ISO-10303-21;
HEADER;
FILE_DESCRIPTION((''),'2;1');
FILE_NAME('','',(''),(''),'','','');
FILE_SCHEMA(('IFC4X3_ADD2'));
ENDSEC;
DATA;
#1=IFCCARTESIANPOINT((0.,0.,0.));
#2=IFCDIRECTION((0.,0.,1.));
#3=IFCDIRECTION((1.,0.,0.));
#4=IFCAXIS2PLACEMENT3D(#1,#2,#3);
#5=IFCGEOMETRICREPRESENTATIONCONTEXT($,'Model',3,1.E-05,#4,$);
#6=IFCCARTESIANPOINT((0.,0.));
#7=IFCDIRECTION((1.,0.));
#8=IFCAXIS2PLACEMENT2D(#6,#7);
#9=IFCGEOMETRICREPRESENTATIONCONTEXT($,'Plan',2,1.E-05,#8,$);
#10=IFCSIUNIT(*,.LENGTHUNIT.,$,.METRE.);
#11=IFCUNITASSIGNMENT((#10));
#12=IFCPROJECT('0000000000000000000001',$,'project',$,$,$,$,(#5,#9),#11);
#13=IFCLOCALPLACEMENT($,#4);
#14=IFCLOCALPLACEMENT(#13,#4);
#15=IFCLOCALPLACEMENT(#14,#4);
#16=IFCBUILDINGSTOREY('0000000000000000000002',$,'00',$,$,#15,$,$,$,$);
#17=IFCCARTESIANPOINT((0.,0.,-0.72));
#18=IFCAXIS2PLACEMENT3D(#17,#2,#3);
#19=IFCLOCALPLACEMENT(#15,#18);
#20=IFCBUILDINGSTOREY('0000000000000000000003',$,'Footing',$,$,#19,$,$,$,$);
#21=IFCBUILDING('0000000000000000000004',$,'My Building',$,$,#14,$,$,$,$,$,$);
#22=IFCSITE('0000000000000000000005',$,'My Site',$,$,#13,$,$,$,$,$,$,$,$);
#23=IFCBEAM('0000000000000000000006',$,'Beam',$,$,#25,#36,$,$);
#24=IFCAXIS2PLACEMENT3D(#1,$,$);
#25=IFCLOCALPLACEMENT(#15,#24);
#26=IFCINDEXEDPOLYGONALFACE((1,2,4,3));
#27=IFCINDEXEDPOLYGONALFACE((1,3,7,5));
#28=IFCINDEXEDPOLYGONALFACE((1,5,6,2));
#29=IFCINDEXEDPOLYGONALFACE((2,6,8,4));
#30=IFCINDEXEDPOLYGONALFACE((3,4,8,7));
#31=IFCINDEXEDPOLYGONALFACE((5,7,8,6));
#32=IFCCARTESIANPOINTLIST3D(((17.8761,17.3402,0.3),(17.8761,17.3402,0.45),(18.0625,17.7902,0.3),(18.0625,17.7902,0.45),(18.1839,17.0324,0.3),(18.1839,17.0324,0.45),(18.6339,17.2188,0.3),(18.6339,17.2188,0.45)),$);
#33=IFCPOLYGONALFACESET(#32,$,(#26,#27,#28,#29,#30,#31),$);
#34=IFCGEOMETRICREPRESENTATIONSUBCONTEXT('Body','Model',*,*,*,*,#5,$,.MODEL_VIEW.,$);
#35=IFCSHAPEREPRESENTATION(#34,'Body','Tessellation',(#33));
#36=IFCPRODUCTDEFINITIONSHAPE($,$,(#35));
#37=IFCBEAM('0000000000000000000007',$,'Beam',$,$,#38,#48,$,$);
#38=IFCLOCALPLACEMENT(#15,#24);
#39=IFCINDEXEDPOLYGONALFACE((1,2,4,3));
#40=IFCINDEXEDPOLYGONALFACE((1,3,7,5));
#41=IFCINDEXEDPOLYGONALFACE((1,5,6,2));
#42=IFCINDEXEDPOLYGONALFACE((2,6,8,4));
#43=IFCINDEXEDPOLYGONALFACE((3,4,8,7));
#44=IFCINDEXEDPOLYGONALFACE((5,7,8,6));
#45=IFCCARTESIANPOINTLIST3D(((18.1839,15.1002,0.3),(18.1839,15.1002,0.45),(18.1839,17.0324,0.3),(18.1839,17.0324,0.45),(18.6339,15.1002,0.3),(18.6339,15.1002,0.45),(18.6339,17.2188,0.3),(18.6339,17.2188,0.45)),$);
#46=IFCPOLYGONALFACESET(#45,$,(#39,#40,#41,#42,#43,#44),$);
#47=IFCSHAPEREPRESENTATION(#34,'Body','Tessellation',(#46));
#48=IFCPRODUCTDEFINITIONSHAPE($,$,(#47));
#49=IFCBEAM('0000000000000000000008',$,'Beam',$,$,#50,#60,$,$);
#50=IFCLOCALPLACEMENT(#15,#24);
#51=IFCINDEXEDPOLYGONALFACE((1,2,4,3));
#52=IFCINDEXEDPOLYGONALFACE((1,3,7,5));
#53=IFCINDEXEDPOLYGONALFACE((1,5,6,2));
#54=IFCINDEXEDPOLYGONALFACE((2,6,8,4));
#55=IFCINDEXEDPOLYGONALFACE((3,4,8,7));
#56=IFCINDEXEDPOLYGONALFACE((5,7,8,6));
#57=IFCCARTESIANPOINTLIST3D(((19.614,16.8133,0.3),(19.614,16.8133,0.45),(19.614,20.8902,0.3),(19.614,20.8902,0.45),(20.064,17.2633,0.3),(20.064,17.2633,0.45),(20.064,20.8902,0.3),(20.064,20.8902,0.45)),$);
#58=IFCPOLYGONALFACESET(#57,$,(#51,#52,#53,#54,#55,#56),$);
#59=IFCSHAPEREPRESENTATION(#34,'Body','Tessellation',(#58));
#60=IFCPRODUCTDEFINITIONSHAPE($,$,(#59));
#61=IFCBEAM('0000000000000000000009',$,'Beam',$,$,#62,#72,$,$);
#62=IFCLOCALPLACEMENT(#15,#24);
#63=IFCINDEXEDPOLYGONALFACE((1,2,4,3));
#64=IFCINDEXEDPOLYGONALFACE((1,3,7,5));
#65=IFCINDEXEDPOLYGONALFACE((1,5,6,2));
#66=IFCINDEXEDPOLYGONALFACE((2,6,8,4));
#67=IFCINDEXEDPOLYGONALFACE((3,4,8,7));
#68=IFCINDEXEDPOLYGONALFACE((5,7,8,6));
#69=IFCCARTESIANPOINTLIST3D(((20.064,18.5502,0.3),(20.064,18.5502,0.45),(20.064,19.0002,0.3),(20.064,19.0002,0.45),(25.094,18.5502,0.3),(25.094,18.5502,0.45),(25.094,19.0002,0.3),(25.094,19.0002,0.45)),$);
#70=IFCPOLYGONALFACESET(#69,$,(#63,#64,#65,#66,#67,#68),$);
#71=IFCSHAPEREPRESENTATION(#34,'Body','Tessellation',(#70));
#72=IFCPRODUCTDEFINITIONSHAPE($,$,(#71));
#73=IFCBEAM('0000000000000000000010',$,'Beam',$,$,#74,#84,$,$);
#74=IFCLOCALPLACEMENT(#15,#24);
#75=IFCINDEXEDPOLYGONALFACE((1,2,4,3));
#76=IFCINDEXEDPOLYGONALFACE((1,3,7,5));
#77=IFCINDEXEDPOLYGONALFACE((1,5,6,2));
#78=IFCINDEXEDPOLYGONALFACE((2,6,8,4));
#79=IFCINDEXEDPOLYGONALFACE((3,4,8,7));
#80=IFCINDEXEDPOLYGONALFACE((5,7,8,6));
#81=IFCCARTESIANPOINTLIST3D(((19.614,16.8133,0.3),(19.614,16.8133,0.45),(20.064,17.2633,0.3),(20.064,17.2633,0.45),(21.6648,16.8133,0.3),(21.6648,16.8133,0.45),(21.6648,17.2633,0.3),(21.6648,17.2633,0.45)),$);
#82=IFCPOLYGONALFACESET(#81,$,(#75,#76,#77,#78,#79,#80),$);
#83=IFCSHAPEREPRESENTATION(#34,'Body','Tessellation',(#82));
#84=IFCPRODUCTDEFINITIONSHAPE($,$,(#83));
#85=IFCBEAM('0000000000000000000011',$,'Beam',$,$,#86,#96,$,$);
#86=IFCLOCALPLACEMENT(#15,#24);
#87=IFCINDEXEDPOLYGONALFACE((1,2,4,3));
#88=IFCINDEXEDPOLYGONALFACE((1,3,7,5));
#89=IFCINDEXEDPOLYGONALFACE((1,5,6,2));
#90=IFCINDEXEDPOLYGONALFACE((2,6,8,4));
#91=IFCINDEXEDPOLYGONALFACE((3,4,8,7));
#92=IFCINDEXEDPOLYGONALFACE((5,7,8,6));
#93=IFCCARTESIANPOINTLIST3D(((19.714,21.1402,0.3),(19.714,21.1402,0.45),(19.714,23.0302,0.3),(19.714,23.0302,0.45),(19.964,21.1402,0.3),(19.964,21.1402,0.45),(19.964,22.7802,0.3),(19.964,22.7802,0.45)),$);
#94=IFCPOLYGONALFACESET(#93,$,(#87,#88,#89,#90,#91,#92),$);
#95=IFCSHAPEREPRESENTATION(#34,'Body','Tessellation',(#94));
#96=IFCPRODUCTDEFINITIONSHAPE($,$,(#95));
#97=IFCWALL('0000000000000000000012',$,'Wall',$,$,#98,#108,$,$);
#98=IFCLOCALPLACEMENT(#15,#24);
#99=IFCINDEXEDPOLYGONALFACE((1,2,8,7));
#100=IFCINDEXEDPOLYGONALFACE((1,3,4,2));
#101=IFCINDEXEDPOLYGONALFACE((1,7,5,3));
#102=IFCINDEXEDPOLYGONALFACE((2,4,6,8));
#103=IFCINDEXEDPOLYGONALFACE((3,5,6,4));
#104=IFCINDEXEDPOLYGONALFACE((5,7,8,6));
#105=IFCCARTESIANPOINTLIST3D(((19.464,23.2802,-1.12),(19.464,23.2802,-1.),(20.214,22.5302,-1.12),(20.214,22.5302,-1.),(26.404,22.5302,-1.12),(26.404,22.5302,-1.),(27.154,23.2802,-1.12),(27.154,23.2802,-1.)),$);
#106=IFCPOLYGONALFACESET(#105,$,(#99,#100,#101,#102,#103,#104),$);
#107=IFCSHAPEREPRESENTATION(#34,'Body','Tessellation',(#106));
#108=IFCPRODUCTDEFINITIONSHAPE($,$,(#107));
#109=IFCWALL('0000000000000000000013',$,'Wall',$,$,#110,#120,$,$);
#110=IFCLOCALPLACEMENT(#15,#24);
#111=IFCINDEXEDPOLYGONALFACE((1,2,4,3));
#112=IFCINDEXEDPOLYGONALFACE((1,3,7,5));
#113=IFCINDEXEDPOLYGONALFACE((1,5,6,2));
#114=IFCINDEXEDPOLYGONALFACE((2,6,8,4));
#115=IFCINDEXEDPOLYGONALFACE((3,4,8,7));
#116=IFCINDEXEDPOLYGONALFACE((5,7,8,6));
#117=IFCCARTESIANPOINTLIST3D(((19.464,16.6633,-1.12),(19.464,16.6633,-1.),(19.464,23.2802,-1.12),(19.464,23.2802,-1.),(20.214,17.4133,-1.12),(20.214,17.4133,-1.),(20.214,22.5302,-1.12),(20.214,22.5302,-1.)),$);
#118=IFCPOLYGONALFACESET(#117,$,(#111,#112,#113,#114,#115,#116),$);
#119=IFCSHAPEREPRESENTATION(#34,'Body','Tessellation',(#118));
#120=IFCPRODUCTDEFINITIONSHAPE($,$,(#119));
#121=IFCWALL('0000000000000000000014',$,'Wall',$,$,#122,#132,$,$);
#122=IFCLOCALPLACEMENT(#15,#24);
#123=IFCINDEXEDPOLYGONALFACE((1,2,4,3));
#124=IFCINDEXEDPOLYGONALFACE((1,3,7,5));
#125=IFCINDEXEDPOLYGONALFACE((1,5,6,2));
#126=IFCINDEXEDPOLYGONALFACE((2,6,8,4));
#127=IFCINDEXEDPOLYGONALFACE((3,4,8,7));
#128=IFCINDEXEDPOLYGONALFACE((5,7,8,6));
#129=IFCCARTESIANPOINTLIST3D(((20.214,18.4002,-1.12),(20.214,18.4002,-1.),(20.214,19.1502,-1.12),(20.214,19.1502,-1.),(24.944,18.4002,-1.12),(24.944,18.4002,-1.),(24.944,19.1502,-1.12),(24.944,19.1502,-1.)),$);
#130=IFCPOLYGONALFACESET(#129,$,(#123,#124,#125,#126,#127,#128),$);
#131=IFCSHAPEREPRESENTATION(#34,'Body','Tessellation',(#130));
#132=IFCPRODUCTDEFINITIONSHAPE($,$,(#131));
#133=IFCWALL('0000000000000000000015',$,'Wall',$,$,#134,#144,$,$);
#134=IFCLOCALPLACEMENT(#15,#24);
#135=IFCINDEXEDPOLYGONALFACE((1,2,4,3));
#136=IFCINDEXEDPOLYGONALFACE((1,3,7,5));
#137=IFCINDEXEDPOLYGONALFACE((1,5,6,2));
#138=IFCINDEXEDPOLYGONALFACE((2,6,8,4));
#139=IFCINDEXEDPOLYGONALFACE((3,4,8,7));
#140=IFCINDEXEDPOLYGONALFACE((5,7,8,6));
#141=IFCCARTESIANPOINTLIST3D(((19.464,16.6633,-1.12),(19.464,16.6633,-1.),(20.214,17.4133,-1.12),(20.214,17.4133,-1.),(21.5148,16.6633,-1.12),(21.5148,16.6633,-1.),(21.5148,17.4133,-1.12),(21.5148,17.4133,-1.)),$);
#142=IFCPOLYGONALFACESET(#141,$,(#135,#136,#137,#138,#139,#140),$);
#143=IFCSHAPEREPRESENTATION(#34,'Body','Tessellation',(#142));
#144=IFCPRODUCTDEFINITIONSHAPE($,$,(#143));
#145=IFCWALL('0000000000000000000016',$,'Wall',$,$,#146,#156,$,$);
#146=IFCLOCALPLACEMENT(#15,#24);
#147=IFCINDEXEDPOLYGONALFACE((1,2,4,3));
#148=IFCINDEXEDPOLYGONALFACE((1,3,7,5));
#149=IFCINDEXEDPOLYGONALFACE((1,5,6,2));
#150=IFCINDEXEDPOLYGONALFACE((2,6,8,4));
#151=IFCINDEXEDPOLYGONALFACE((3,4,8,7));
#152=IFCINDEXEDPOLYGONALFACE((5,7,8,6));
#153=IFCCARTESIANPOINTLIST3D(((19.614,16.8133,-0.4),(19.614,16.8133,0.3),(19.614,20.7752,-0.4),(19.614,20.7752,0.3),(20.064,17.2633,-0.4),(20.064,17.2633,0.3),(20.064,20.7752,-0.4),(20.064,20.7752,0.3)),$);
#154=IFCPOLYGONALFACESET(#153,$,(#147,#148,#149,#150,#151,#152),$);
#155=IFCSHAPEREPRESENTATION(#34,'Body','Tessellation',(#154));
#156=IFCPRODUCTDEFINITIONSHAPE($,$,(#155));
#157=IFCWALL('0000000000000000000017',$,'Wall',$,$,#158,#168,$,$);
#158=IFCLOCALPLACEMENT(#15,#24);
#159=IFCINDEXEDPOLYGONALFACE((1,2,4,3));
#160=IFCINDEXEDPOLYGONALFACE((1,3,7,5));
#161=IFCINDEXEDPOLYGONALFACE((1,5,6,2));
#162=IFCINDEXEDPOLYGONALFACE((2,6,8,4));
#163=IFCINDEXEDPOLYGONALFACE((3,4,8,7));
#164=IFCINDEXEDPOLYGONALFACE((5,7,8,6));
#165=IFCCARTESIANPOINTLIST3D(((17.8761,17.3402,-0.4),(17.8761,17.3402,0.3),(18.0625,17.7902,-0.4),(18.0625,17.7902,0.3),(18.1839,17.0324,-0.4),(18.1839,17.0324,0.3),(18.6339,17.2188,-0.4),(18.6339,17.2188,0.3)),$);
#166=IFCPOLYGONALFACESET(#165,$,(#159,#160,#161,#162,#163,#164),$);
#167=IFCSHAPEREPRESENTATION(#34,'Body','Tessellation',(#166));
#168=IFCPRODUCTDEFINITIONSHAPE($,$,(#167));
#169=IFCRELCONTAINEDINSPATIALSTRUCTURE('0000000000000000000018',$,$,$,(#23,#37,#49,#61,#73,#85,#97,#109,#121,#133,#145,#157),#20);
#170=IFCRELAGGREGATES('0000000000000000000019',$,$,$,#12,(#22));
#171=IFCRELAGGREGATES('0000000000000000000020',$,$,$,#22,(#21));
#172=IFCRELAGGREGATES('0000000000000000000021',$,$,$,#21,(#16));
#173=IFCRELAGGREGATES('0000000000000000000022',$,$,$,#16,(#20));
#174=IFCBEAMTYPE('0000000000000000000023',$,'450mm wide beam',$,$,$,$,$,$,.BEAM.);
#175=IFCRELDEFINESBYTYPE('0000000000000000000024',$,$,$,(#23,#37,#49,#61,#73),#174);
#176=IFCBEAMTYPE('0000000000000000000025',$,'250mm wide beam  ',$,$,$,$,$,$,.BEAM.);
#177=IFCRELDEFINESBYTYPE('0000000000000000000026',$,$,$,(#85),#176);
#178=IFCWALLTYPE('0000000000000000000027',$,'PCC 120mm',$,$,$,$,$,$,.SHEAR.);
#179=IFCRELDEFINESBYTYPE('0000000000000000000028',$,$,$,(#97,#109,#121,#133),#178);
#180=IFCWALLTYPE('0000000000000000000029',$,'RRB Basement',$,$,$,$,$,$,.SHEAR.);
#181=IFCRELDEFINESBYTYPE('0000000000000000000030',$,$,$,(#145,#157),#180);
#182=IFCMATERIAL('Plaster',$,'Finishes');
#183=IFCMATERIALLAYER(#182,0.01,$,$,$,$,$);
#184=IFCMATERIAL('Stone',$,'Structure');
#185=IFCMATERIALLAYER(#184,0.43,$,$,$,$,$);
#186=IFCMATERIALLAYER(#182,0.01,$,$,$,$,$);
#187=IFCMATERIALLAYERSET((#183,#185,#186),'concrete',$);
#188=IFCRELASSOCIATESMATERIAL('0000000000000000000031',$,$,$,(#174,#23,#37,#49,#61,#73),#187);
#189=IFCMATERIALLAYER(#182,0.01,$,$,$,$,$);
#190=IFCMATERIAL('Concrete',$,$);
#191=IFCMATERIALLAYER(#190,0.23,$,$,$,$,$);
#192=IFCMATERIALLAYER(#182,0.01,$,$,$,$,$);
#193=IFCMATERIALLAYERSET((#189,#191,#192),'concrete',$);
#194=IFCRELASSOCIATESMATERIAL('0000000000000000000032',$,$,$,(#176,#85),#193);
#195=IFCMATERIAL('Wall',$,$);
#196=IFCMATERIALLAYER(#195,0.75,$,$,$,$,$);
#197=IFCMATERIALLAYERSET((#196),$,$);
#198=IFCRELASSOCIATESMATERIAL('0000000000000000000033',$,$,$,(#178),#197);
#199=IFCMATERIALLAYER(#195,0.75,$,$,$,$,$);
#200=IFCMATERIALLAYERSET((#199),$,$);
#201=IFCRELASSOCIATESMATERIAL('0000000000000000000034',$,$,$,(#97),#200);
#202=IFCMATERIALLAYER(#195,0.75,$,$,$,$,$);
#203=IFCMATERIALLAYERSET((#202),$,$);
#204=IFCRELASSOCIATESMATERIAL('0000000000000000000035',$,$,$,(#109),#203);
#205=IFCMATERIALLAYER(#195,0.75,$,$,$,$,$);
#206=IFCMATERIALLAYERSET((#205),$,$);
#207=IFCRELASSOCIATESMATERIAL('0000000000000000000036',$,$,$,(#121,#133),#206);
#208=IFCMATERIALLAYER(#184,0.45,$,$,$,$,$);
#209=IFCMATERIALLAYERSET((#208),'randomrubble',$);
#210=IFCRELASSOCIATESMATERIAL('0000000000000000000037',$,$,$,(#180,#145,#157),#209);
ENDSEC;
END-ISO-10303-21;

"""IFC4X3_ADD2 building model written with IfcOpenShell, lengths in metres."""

from ifc_helpers import new_model, si_unit, frame, origin_with_axes, origin_2d_with_axis, place, context, subcontext, project, spatial, line, indexed_curve, outline, extrude, material, layer, layer_set, layer_usage, type_object, element, save


model = new_model("IFC4X3_ADD2")

# Units and contexts
model_context = context("Model", 3, precision=1e-05, world=origin_with_axes())
plan_context = context("Plan", 2, precision=1e-05, world=origin_2d_with_axis())
body_context = subcontext(model_context, "Body", "Model", "MODEL_VIEW")
ifc_project = project(units=[si_unit("LENGTHUNIT", "METRE")], contexts=[model_context, plan_context])

# Site, building, storeys
site_placement = place(None, origin_with_axes())
site = spatial("IfcSite", under=ifc_project, at=site_placement, Name="My Site")
building_placement = place(site_placement, origin_with_axes())
building = spatial("IfcBuilding", under=site, at=building_placement, Name="My Building")
storey_1_placement = place(building_placement, origin_with_axes())
storey_1 = spatial("IfcBuildingStorey", under=building, at=storey_1_placement, Name="00")
storey_2_placement = place(storey_1_placement, frame((0.0, 0.0, -0.72), z_axis=(0.0, 0.0, 1.0), x_axis=(1.0, 0.0, 0.0)))
storey_2 = spatial("IfcBuildingStorey", under=storey_1, at=storey_2_placement, Name="Footing")

# Beams
ifc_material_1 = material(Name="Plaster", Category="Finishes")
ifc_layer_1 = layer(ifc_material_1, 0.01)
ifc_material_2 = material(Name="Stone", Category="Structure")
ifc_layer_2 = layer(ifc_material_2, 0.43)
ifc_layer_3 = layer(ifc_material_1, 0.01)
ifc_layer_set_1 = layer_set([ifc_layer_1, ifc_layer_2, ifc_layer_3], Name="concrete")
ifc_layer_usage_1 = layer_usage(ifc_layer_set_1, "AXIS2", "NEGATIVE", 0.0)
beam_type_1 = type_object("IfcBeamType", Name="450mm wide beam", PredefinedType="BEAM", material=ifc_layer_set_1)
beam_1_placement = place(storey_2_placement, frame((18.1839, 17.0324, 1.02), z_axis=(0.0, 0.0, 1.0), x_axis=(-0.707107, 0.707107, 0.0)))
element("IfcBeam", 1, at=beam_1_placement, inside=storey_2, type_object=beam_type_1, material=ifc_layer_usage_1, Name="Beam", context=body_context, shape_type="SweptSolid", body=[
    extrude(outline(indexed_curve([(-0.1864, -0.45), (0.0, 0.0), (0.4353, 0.0), (0.6217, -0.45)], segments=[line(1, 2, 3, 4, 1)])), origin_with_axes(), (0.0, 0.0, 1.0), 0.15),
])
ifc_layer_usage_2 = layer_usage(ifc_layer_set_1, "AXIS2", "POSITIVE", 0.0)
beam_2_placement = place(storey_2_placement, frame((18.1839, 17.0324, 1.02), z_axis=(0.0, 0.0, 1.0), x_axis=(0.0, -1.0, 0.0)))
element("IfcBeam", 2, at=beam_2_placement, inside=storey_2, type_object=beam_type_1, material=ifc_layer_usage_2, Name="Beam", context=body_context, shape_type="SweptSolid", body=[
    extrude(outline(indexed_curve([(0.0, 0.0), (-0.1864, 0.45), (1.9322, 0.45), (1.9322, 0.0)], segments=[line(1, 2, 3, 4, 1)])), origin_with_axes(), (0.0, 0.0, 1.0), 0.15),
])
ifc_layer_usage_3 = layer_usage(ifc_layer_set_1, "AXIS2", "NEGATIVE", 0.0)
beam_3_placement = place(storey_2_placement, frame((20.064, 20.8902, 1.02), z_axis=(0.0, 0.0, 1.0), x_axis=(0.0, -1.0, 0.0)))
element("IfcBeam", 3, at=beam_3_placement, inside=storey_2, type_object=beam_type_1, material=ifc_layer_usage_3, Name="Beam", context=body_context, shape_type="SweptSolid", body=[
    extrude(outline(indexed_curve([(0.0, -0.45), (0.0, 0.0), (3.6269, 0.0), (4.0769, -0.45)], segments=[line(1, 2, 3, 4, 1)])), origin_with_axes(), (0.0, 0.0, 1.0), 0.15),
])
ifc_layer_usage_4 = layer_usage(ifc_layer_set_1, "AXIS2", "NEGATIVE", 0.0)
beam_4_placement = place(storey_2_placement, frame((20.064, 19.0002, 1.02), z_axis=(0.0, 0.0, 1.0), x_axis=(1.0, 0.0, 0.0)))
element("IfcBeam", 4, at=beam_4_placement, inside=storey_2, type_object=beam_type_1, material=ifc_layer_usage_4, Name="Beam", context=body_context, shape_type="SweptSolid", body=[
    extrude(outline(indexed_curve([(0.0, -0.45), (0.0, 0.0), (5.03, 0.0), (5.03, -0.45)], segments=[line(1, 2, 3, 4, 1)])), origin_with_axes(), (0.0, 0.0, 1.0), 0.15),
])
ifc_layer_usage_5 = layer_usage(ifc_layer_set_1, "AXIS2", "NEGATIVE", 0.0)
beam_5_placement = place(storey_2_placement, frame((20.064, 17.2633, 1.02), z_axis=(0.0, 0.0, 1.0), x_axis=(1.0, 0.0, 0.0)))
element("IfcBeam", 5, at=beam_5_placement, inside=storey_2, type_object=beam_type_1, material=ifc_layer_usage_5, Name="Beam", context=body_context, shape_type="SweptSolid", body=[
    extrude(outline(indexed_curve([(-0.45, -0.45), (0.0, 0.0), (1.6008, 0.0), (1.6008, -0.45)], segments=[line(1, 2, 3, 4, 1)])), origin_with_axes(), (0.0, 0.0, 1.0), 0.15),
])
ifc_layer_4 = layer(ifc_material_1, 0.01)
ifc_material_3 = material(Name="Concrete")
ifc_layer_5 = layer(ifc_material_3, 0.23)
ifc_layer_6 = layer(ifc_material_1, 0.01)
ifc_layer_set_2 = layer_set([ifc_layer_4, ifc_layer_5, ifc_layer_6], Name="concrete")
ifc_layer_usage_6 = layer_usage(ifc_layer_set_2, "AXIS2", "POSITIVE", 0.0)
beam_type_2 = type_object("IfcBeamType", Name="250mm wide beam  ", PredefinedType="BEAM", material=ifc_layer_set_2)
beam_6_placement = place(storey_2_placement, frame((19.714, 22.7802, 1.02), z_axis=(0.0, 0.0, 1.0), x_axis=(0.0, -1.0, 0.0)))
element("IfcBeam", 6, at=beam_6_placement, inside=storey_2, type_object=beam_type_2, material=ifc_layer_usage_6, Name="Beam", context=body_context, shape_type="SweptSolid", body=[
    extrude(outline(indexed_curve([(-0.25, 0.0), (0.0, 0.25), (1.64, 0.25), (1.64, 0.0)], segments=[line(1, 2, 3, 4, 1)])), origin_with_axes(), (0.0, 0.0, 1.0), 0.15),
])

# Walls
ifc_material_4 = material(Name="Wall")
ifc_layer_7 = layer(ifc_material_4, 0.75)
ifc_layer_set_3 = layer_set([ifc_layer_7])
ifc_layer_usage_7 = layer_usage(ifc_layer_set_3, "AXIS2", "POSITIVE", 0.0)
ifc_layer_8 = layer(ifc_material_4, 0.75)
ifc_layer_set_4 = layer_set([ifc_layer_8])
wall_type_1 = type_object("IfcWallType", Name="PCC 120mm", PredefinedType="SHEAR", material=ifc_layer_set_4)
wall_1_placement = place(storey_2_placement, frame((20.214, 22.5302, -0.4), z_axis=(0.0, 0.0, 1.0), x_axis=(1.0, 0.0, 0.0)))
element("IfcWall", 7, at=wall_1_placement, inside=storey_2, type_object=wall_type_1, material=ifc_layer_usage_7, Name="Wall", context=body_context, shape_type="SweptSolid", body=[
    extrude(outline(indexed_curve([(0.0, 0.0), (-0.75, 0.75), (6.94, 0.75), (6.19, 0.0)], segments=[line(1, 2, 3, 4, 1)])), origin_with_axes(), (0.0, 0.0, 1.0), 0.12),
])
ifc_layer_9 = layer(ifc_material_4, 0.75)
ifc_layer_set_5 = layer_set([ifc_layer_9])
ifc_layer_usage_8 = layer_usage(ifc_layer_set_5, "AXIS2", "POSITIVE", 0.0)
wall_2_placement = place(storey_2_placement, frame((20.214, 16.6633, -0.4), z_axis=(0.0, 0.0, 1.0), x_axis=(0.0, 1.0, 0.0)))
element("IfcWall", 8, at=wall_2_placement, inside=storey_2, type_object=wall_type_1, material=ifc_layer_usage_8, Name="Wall", context=body_context, shape_type="SweptSolid", body=[
    extrude(outline(indexed_curve([(0.75, 0.0), (0.0, 0.75), (6.6169, 0.75), (5.8669, 0.0)], segments=[line(1, 2, 3, 4, 1)])), origin_with_axes(), (0.0, 0.0, 1.0), 0.12),
])
ifc_layer_10 = layer(ifc_material_4, 0.75)
ifc_layer_set_6 = layer_set([ifc_layer_10])
ifc_layer_usage_9 = layer_usage(ifc_layer_set_6, "AXIS2", "POSITIVE", 0.0)
wall_3_placement = place(storey_2_placement, frame((20.214, 18.4002, -0.4), z_axis=(0.0, 0.0, 1.0), x_axis=(1.0, 0.0, 0.0)))
element("IfcWall", 9, at=wall_3_placement, inside=storey_2, type_object=wall_type_1, material=ifc_layer_usage_9, Name="Wall", context=body_context, shape_type="SweptSolid", body=[
    extrude(outline(indexed_curve([(0.0, 0.0), (0.0, 0.75), (4.73, 0.75), (4.73, 0.0)], segments=[line(1, 2, 3, 4, 1)])), origin_with_axes(), (0.0, 0.0, 1.0), 0.12),
])
ifc_layer_usage_10 = layer_usage(ifc_layer_set_6, "AXIS2", "POSITIVE", 0.0)
wall_4_placement = place(storey_2_placement, frame((20.214, 16.6633, -0.4), z_axis=(0.0, 0.0, 1.0), x_axis=(1.0, 0.0, 0.0)))
element("IfcWall", 10, at=wall_4_placement, inside=storey_2, type_object=wall_type_1, material=ifc_layer_usage_10, Name="Wall", context=body_context, shape_type="SweptSolid", body=[
    extrude(outline(indexed_curve([(-0.75, 0.0), (0.0, 0.75), (1.3008, 0.75), (1.3008, 0.0)], segments=[line(1, 2, 3, 4, 1)])), origin_with_axes(), (0.0, 0.0, 1.0), 0.12),
])
ifc_layer_11 = layer(ifc_material_2, 0.45)
ifc_layer_set_7 = layer_set([ifc_layer_11], Name="randomrubble")
ifc_layer_usage_11 = layer_usage(ifc_layer_set_7, "AXIS2", "NEGATIVE", 0.0)
wall_type_2 = type_object("IfcWallType", Name="RRB Basement", PredefinedType="SHEAR", material=ifc_layer_set_7)
wall_5_placement = place(storey_2_placement, frame((19.614, 16.8133, 0.32), z_axis=(0.0, 0.0, 1.0), x_axis=(0.0, 1.0, 0.0)))
element("IfcWall", 11, at=wall_5_placement, inside=storey_2, type_object=wall_type_2, material=ifc_layer_usage_11, Name="Wall", context=body_context, shape_type="SweptSolid", body=[
    extrude(outline(indexed_curve([(0.45, -0.45), (0.0, 0.0), (3.9619, 0.0), (3.9619, -0.45)], segments=[line(1, 2, 3, 4, 1)])), origin_with_axes(), (0.0, 0.0, 1.0), 0.7),
])
ifc_layer_usage_12 = layer_usage(ifc_layer_set_7, "AXIS2", "POSITIVE", 0.0)
wall_6_placement = place(storey_2_placement, frame((18.6339, 17.2188, 0.32), z_axis=(0.0, 0.0, 1.0), x_axis=(-0.707107, 0.707107, 0.0)))
element("IfcWall", 12, at=wall_6_placement, inside=storey_2, type_object=wall_type_2, material=ifc_layer_usage_12, Name="Wall", context=body_context, shape_type="SweptSolid", body=[
    extrude(outline(indexed_curve([(0.0, 0.0), (0.1864, 0.45), (0.6217, 0.45), (0.8081, 0.0)], segments=[line(1, 2, 3, 4, 1)])), origin_with_axes(), (0.0, 0.0, 1.0), 0.7),
])

save(model, "model.ifc")
